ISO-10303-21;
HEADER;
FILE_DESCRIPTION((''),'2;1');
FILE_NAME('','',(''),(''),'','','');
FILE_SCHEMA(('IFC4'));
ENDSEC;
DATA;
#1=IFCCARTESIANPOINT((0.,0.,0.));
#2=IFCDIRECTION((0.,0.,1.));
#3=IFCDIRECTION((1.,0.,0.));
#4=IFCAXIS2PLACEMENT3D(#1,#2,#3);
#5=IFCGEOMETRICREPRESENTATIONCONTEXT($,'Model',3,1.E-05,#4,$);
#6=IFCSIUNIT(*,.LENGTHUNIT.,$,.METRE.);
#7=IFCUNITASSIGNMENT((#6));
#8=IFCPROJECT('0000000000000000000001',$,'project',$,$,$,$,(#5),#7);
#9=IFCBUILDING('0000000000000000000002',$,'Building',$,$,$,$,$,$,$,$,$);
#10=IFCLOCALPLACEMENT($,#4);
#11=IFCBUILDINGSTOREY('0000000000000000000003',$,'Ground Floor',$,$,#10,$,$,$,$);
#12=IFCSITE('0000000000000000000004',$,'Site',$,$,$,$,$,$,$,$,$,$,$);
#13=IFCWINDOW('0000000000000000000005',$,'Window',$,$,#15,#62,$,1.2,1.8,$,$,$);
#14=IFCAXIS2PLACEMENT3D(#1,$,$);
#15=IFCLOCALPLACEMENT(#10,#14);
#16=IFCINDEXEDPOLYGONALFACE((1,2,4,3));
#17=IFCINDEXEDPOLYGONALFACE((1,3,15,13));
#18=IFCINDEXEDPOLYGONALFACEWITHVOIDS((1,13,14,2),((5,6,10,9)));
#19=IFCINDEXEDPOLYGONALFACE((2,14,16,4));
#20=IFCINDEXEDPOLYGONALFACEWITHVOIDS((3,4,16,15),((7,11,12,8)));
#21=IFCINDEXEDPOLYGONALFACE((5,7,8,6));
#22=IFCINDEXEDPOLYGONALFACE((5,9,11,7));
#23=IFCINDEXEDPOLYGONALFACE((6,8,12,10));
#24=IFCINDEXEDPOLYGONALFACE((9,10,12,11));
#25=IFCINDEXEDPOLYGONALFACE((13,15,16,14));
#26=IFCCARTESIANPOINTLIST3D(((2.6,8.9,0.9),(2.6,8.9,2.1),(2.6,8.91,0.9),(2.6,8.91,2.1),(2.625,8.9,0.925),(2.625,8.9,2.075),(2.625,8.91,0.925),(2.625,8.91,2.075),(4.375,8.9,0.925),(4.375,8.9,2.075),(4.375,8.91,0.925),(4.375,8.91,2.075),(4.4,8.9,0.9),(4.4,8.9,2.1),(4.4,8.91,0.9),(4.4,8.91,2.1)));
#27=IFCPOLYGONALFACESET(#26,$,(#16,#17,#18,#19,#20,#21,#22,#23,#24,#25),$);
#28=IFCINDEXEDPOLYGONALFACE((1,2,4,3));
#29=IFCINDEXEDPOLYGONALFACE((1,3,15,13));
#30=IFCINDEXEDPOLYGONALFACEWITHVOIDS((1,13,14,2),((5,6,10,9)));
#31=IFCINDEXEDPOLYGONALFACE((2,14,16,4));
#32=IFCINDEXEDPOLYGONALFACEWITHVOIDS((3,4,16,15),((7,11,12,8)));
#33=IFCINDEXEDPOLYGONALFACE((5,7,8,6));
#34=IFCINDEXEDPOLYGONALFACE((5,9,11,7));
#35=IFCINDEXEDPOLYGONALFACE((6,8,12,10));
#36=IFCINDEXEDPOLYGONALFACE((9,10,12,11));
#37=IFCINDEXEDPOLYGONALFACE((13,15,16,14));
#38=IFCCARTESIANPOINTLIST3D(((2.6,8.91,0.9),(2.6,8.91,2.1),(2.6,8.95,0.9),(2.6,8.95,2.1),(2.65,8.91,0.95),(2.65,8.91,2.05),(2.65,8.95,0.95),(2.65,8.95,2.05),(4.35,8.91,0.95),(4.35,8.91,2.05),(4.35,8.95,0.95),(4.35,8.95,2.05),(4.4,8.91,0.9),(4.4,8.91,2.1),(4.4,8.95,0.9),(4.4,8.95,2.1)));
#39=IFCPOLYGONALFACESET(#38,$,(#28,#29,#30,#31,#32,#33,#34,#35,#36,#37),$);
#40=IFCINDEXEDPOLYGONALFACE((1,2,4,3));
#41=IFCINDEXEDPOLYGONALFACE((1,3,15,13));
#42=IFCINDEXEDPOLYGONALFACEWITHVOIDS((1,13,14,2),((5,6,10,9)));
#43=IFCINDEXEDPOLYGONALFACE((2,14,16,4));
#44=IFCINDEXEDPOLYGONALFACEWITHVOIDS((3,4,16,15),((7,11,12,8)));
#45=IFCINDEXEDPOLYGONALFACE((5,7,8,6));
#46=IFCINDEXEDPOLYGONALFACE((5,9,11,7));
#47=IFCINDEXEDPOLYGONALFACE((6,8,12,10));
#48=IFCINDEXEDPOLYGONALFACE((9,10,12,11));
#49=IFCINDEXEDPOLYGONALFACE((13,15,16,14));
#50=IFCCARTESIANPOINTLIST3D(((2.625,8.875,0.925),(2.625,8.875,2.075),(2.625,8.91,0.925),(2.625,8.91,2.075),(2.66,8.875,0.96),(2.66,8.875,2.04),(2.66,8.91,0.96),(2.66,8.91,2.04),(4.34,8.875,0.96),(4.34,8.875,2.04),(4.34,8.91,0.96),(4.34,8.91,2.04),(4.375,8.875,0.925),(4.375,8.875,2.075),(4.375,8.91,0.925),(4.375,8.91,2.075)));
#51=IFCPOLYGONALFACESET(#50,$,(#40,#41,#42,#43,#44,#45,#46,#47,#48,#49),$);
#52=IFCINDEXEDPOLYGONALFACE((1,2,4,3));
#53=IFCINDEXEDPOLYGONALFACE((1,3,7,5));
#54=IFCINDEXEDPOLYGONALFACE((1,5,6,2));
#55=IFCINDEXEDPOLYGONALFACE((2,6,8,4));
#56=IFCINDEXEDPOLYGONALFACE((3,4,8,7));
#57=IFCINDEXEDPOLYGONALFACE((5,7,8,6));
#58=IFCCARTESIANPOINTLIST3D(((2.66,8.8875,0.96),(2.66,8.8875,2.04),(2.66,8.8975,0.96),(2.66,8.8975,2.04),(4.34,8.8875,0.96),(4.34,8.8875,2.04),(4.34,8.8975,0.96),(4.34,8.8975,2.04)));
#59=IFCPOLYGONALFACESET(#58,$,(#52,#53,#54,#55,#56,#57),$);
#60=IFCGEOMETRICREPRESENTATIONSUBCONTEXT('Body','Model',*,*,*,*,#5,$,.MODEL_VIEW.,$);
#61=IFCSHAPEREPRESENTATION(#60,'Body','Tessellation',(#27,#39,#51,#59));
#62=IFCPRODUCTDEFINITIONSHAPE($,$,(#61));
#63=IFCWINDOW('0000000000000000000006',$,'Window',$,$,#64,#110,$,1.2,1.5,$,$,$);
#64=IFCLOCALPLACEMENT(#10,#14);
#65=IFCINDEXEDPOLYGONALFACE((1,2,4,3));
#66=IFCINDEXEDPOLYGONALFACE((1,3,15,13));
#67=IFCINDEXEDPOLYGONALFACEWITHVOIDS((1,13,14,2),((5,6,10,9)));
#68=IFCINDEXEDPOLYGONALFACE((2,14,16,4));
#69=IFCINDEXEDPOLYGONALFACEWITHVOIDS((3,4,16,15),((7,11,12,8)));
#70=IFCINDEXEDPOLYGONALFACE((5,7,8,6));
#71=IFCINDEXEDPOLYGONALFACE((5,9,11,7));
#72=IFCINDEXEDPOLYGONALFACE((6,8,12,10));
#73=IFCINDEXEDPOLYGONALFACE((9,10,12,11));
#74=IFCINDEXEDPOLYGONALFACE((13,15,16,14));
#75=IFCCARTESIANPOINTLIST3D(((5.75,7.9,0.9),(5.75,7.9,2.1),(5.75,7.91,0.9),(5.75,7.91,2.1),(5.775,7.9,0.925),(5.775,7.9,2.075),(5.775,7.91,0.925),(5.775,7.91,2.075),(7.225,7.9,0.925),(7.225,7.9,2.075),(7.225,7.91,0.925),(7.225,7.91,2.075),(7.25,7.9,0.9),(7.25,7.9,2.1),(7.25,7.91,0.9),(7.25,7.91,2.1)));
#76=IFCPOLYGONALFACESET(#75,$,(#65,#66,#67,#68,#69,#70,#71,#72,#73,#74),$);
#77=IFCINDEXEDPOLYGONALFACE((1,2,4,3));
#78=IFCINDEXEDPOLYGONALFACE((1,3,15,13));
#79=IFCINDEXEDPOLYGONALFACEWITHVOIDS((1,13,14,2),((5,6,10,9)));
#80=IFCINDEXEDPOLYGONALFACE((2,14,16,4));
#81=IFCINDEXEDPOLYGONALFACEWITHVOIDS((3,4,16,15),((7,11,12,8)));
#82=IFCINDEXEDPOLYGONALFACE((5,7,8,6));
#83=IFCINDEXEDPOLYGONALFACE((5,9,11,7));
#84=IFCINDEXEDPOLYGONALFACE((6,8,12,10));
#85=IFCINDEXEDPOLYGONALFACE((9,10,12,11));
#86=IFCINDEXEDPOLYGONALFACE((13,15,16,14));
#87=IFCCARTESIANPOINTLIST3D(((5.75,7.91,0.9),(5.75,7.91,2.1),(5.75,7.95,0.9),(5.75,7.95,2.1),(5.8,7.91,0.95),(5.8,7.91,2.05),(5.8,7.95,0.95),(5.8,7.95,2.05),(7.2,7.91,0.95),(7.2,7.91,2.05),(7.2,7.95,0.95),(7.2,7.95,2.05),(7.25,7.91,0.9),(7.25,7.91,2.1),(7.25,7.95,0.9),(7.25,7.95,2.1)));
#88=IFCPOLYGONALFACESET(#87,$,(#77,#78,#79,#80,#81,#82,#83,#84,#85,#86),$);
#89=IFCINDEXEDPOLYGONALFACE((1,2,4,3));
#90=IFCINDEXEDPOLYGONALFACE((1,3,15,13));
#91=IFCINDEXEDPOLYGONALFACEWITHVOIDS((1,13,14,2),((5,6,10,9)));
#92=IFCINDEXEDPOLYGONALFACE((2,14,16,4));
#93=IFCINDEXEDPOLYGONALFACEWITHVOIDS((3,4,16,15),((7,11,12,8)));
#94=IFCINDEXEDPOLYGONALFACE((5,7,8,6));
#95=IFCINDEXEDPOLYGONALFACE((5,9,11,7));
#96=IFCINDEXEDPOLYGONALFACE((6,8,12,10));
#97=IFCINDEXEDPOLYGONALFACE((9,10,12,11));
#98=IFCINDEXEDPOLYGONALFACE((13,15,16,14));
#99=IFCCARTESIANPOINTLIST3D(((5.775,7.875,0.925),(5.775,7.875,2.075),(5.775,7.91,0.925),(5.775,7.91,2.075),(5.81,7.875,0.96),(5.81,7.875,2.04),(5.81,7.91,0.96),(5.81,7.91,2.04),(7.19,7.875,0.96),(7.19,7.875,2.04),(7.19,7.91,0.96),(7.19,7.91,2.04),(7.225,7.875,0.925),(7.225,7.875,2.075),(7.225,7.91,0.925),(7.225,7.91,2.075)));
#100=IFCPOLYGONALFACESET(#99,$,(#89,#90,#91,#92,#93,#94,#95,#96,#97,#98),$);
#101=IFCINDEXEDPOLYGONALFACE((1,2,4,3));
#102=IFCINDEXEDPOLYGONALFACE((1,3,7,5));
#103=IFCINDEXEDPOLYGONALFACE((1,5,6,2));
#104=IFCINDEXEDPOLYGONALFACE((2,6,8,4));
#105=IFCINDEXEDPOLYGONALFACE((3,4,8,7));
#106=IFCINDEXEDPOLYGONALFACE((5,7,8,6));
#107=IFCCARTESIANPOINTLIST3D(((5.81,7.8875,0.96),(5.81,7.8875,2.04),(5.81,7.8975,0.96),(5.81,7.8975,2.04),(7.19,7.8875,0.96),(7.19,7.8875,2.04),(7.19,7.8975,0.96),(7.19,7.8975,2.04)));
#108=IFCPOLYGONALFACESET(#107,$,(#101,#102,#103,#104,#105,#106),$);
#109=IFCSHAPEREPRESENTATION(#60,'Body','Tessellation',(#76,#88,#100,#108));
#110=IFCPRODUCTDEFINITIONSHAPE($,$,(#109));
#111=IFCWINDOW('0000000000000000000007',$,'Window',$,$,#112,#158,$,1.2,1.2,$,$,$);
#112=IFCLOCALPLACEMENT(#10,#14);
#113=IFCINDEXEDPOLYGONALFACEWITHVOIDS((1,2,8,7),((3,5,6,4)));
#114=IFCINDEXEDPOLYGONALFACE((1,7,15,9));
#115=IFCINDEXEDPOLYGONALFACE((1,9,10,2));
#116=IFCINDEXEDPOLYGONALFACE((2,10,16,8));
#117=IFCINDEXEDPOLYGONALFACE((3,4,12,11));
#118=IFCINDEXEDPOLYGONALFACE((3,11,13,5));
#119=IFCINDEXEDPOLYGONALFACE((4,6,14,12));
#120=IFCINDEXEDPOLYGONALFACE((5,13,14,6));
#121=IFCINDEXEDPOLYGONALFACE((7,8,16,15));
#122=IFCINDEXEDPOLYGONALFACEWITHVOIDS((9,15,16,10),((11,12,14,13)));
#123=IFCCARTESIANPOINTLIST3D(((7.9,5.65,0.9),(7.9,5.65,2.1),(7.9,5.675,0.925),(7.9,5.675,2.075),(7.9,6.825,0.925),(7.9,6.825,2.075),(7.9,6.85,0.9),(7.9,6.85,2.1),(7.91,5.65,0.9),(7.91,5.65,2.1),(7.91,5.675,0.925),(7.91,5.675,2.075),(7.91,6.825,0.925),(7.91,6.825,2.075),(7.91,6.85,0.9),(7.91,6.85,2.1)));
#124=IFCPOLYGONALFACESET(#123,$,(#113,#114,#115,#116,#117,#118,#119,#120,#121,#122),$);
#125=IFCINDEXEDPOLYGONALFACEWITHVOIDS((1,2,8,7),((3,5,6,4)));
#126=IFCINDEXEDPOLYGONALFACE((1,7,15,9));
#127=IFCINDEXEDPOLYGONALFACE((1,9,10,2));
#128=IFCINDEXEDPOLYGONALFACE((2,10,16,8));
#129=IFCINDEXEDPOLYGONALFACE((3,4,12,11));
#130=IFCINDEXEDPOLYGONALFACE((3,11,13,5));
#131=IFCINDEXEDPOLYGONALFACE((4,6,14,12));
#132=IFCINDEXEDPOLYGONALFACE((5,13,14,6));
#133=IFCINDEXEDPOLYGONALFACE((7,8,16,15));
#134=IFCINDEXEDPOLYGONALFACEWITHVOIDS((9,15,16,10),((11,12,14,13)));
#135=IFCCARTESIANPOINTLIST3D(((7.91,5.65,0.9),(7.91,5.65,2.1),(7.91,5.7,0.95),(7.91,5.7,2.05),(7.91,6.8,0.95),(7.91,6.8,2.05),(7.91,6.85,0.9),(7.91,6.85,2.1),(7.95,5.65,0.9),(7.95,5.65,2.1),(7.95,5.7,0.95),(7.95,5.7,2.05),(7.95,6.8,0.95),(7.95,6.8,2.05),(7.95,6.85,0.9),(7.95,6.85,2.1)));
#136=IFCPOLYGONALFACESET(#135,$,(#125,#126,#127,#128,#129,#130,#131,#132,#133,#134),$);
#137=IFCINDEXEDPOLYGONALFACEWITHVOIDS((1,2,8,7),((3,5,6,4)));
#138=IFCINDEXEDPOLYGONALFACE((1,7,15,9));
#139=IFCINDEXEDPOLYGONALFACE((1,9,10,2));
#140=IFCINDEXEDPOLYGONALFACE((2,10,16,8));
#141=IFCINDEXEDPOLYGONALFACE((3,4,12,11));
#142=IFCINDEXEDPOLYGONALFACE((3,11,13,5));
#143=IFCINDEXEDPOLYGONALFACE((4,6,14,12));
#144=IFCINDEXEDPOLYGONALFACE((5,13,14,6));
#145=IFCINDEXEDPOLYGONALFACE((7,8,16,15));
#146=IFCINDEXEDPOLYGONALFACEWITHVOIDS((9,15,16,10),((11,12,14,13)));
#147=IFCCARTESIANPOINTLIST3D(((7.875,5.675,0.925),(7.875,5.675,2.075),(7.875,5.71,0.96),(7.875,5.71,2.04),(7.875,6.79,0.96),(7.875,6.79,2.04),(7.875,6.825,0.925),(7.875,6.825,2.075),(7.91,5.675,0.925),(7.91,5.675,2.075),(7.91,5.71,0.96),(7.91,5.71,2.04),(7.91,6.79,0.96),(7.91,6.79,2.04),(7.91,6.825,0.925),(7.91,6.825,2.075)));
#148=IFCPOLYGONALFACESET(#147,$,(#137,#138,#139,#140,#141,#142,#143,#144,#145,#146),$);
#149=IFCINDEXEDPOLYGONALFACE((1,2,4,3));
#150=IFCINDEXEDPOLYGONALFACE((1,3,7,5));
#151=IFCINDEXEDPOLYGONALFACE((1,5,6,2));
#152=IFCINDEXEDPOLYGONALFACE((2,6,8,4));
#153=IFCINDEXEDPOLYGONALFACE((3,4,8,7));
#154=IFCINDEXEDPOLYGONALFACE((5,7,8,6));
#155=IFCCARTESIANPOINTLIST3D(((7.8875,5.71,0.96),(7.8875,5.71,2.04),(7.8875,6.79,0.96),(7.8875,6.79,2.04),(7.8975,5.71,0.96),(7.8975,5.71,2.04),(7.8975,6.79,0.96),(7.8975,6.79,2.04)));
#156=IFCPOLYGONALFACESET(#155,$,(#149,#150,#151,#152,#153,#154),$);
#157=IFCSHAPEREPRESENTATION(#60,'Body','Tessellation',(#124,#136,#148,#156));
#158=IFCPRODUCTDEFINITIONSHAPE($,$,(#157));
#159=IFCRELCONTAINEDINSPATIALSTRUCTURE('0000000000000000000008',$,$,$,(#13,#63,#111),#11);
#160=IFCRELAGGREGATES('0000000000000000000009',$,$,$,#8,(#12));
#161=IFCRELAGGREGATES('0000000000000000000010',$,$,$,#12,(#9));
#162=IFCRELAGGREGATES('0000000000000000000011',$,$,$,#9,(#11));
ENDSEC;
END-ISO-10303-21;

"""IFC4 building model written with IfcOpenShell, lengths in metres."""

from ifc_helpers import new_model, si_unit, frame, origin_with_axes, place, context, subcontext, project, spatial, line, indexed_curve, outline, extrude, element, save


model = new_model("IFC4")

# Units and contexts
model_context = context("Model", 3, precision=1e-05, world=origin_with_axes())
body_context = subcontext(model_context, "Body", "Model", "MODEL_VIEW")
ifc_project = project(units=[si_unit("LENGTHUNIT", "METRE")], contexts=[model_context])

# Site, building, storey
site = spatial("IfcSite", under=ifc_project, Name="Site")
building = spatial("IfcBuilding", under=site, Name="Building")
storey_placement = place(None, origin_with_axes())
storey = spatial("IfcBuildingStorey", under=building, at=storey_placement, Name="Ground Floor")

# Windows
window_1_placement = place(storey_placement, frame((4.4, 9.0, 0.9), z_axis=(0.0, 0.0, 1.0), x_axis=(-1.0, 0.0, 0.0)))
element("IfcWindow", 1, at=window_1_placement, inside=storey, Name="Window", OverallHeight=1.2, OverallWidth=1.8, context=body_context, shape_type="SweptSolid", body=[
    extrude(outline(indexed_curve([(0.0, 0.0), (1.8, 0.0), (1.8, 1.2), (0.0, 1.2)], segments=[line(1, 2, 3, 4, 1)]), holes=[indexed_curve([(0.025, 0.025), (1.775, 0.025), (1.775, 1.175), (0.025, 1.175)], segments=[line(1, 2, 3, 4, 1)])]), frame((0.0, 0.09, 0.0), z_axis=(0.0, -1.0, 0.0), x_axis=(1.0, 0.0, 0.0)), (0.0, 0.0, -1.0), 0.01),
    extrude(outline(indexed_curve([(0.0, 0.0), (1.8, 0.0), (1.8, 1.2), (0.0, 1.2)], segments=[line(1, 2, 3, 4, 1)]), holes=[indexed_curve([(0.05, 0.05), (1.75, 0.05), (1.75, 1.15), (0.05, 1.15)], segments=[line(1, 2, 3, 4, 1)])]), frame((0.0, 0.05, 0.0), z_axis=(0.0, -1.0, 0.0), x_axis=(1.0, 0.0, 0.0)), (0.0, 0.0, -1.0), 0.04),
    extrude(outline(indexed_curve([(0.0, 0.0), (1.75, 0.0), (1.75, 1.15), (0.0, 1.15)], segments=[line(1, 2, 3, 4, 1)]), holes=[indexed_curve([(0.035, 0.035), (1.715, 0.035), (1.715, 1.115), (0.035, 1.115)], segments=[line(1, 2, 3, 4, 1)])]), frame((0.025, 0.09, 0.025), z_axis=(0.0, -1.0, 0.0), x_axis=(1.0, 0.0, 0.0)), (0.0, 0.0, -1.0), 0.035),
    extrude(outline(indexed_curve([(0.035, 0.035), (1.715, 0.035), (1.715, 1.115), (0.035, 1.115)], segments=[line(1, 2, 3, 4, 1)])), frame((0.025, 0.1025, 0.025), z_axis=(0.0, -1.0, 0.0), x_axis=(1.0, 0.0, 0.0)), (0.0, 0.0, -1.0), 0.01),
])
window_2_placement = place(storey_placement, frame((7.25, 8.0, 0.9), z_axis=(0.0, 0.0, 1.0), x_axis=(-1.0, 0.0, 0.0)))
element("IfcWindow", 2, at=window_2_placement, inside=storey, Name="Window", OverallHeight=1.2, OverallWidth=1.5, context=body_context, shape_type="SweptSolid", body=[
    extrude(outline(indexed_curve([(0.0, 0.0), (1.5, 0.0), (1.5, 1.2), (0.0, 1.2)], segments=[line(1, 2, 3, 4, 1)]), holes=[indexed_curve([(0.025, 0.025), (1.475, 0.025), (1.475, 1.175), (0.025, 1.175)], segments=[line(1, 2, 3, 4, 1)])]), frame((0.0, 0.09, 0.0), z_axis=(0.0, -1.0, 0.0), x_axis=(1.0, 0.0, 0.0)), (0.0, 0.0, -1.0), 0.01),
    extrude(outline(indexed_curve([(0.0, 0.0), (1.5, 0.0), (1.5, 1.2), (0.0, 1.2)], segments=[line(1, 2, 3, 4, 1)]), holes=[indexed_curve([(0.05, 0.05), (1.45, 0.05), (1.45, 1.15), (0.05, 1.15)], segments=[line(1, 2, 3, 4, 1)])]), frame((0.0, 0.05, 0.0), z_axis=(0.0, -1.0, 0.0), x_axis=(1.0, 0.0, 0.0)), (0.0, 0.0, -1.0), 0.04),
    extrude(outline(indexed_curve([(0.0, 0.0), (1.45, 0.0), (1.45, 1.15), (0.0, 1.15)], segments=[line(1, 2, 3, 4, 1)]), holes=[indexed_curve([(0.035, 0.035), (1.415, 0.035), (1.415, 1.115), (0.035, 1.115)], segments=[line(1, 2, 3, 4, 1)])]), frame((0.025, 0.09, 0.025), z_axis=(0.0, -1.0, 0.0), x_axis=(1.0, 0.0, 0.0)), (0.0, 0.0, -1.0), 0.035),
    extrude(outline(indexed_curve([(0.035, 0.035), (1.415, 0.035), (1.415, 1.115), (0.035, 1.115)], segments=[line(1, 2, 3, 4, 1)])), frame((0.025, 0.1025, 0.025), z_axis=(0.0, -1.0, 0.0), x_axis=(1.0, 0.0, 0.0)), (0.0, 0.0, -1.0), 0.01),
])
window_3_placement = place(storey_placement, frame((8.0, 5.65, 0.9), z_axis=(0.0, 0.0, 1.0), x_axis=(0.0, 1.0, 0.0)))
element("IfcWindow", 3, at=window_3_placement, inside=storey, Name="Window", OverallHeight=1.2, OverallWidth=1.2, context=body_context, shape_type="SweptSolid", body=[
    extrude(outline(indexed_curve([(0.0, 0.0), (1.2, 0.0), (1.2, 1.2), (0.0, 1.2)], segments=[line(1, 2, 3, 4, 1)]), holes=[indexed_curve([(0.025, 0.025), (1.175, 0.025), (1.175, 1.175), (0.025, 1.175)], segments=[line(1, 2, 3, 4, 1)])]), frame((0.0, 0.09, 0.0), z_axis=(0.0, -1.0, 0.0), x_axis=(1.0, 0.0, 0.0)), (0.0, 0.0, -1.0), 0.01),
    extrude(outline(indexed_curve([(0.0, 0.0), (1.2, 0.0), (1.2, 1.2), (0.0, 1.2)], segments=[line(1, 2, 3, 4, 1)]), holes=[indexed_curve([(0.05, 0.05), (1.15, 0.05), (1.15, 1.15), (0.05, 1.15)], segments=[line(1, 2, 3, 4, 1)])]), frame((0.0, 0.05, 0.0), z_axis=(0.0, -1.0, 0.0), x_axis=(1.0, 0.0, 0.0)), (0.0, 0.0, -1.0), 0.04),
    extrude(outline(indexed_curve([(0.0, 0.0), (1.15, 0.0), (1.15, 1.15), (0.0, 1.15)], segments=[line(1, 2, 3, 4, 1)]), holes=[indexed_curve([(0.035, 0.035), (1.115, 0.035), (1.115, 1.115), (0.035, 1.115)], segments=[line(1, 2, 3, 4, 1)])]), frame((0.025, 0.09, 0.025), z_axis=(0.0, -1.0, 0.0), x_axis=(1.0, 0.0, 0.0)), (0.0, 0.0, -1.0), 0.035),
    extrude(outline(indexed_curve([(0.035, 0.035), (1.115, 0.035), (1.115, 1.115), (0.035, 1.115)], segments=[line(1, 2, 3, 4, 1)])), frame((0.025, 0.1025, 0.025), z_axis=(0.0, -1.0, 0.0), x_axis=(1.0, 0.0, 0.0)), (0.0, 0.0, -1.0), 0.01),
])

save(model, "model.ifc")
